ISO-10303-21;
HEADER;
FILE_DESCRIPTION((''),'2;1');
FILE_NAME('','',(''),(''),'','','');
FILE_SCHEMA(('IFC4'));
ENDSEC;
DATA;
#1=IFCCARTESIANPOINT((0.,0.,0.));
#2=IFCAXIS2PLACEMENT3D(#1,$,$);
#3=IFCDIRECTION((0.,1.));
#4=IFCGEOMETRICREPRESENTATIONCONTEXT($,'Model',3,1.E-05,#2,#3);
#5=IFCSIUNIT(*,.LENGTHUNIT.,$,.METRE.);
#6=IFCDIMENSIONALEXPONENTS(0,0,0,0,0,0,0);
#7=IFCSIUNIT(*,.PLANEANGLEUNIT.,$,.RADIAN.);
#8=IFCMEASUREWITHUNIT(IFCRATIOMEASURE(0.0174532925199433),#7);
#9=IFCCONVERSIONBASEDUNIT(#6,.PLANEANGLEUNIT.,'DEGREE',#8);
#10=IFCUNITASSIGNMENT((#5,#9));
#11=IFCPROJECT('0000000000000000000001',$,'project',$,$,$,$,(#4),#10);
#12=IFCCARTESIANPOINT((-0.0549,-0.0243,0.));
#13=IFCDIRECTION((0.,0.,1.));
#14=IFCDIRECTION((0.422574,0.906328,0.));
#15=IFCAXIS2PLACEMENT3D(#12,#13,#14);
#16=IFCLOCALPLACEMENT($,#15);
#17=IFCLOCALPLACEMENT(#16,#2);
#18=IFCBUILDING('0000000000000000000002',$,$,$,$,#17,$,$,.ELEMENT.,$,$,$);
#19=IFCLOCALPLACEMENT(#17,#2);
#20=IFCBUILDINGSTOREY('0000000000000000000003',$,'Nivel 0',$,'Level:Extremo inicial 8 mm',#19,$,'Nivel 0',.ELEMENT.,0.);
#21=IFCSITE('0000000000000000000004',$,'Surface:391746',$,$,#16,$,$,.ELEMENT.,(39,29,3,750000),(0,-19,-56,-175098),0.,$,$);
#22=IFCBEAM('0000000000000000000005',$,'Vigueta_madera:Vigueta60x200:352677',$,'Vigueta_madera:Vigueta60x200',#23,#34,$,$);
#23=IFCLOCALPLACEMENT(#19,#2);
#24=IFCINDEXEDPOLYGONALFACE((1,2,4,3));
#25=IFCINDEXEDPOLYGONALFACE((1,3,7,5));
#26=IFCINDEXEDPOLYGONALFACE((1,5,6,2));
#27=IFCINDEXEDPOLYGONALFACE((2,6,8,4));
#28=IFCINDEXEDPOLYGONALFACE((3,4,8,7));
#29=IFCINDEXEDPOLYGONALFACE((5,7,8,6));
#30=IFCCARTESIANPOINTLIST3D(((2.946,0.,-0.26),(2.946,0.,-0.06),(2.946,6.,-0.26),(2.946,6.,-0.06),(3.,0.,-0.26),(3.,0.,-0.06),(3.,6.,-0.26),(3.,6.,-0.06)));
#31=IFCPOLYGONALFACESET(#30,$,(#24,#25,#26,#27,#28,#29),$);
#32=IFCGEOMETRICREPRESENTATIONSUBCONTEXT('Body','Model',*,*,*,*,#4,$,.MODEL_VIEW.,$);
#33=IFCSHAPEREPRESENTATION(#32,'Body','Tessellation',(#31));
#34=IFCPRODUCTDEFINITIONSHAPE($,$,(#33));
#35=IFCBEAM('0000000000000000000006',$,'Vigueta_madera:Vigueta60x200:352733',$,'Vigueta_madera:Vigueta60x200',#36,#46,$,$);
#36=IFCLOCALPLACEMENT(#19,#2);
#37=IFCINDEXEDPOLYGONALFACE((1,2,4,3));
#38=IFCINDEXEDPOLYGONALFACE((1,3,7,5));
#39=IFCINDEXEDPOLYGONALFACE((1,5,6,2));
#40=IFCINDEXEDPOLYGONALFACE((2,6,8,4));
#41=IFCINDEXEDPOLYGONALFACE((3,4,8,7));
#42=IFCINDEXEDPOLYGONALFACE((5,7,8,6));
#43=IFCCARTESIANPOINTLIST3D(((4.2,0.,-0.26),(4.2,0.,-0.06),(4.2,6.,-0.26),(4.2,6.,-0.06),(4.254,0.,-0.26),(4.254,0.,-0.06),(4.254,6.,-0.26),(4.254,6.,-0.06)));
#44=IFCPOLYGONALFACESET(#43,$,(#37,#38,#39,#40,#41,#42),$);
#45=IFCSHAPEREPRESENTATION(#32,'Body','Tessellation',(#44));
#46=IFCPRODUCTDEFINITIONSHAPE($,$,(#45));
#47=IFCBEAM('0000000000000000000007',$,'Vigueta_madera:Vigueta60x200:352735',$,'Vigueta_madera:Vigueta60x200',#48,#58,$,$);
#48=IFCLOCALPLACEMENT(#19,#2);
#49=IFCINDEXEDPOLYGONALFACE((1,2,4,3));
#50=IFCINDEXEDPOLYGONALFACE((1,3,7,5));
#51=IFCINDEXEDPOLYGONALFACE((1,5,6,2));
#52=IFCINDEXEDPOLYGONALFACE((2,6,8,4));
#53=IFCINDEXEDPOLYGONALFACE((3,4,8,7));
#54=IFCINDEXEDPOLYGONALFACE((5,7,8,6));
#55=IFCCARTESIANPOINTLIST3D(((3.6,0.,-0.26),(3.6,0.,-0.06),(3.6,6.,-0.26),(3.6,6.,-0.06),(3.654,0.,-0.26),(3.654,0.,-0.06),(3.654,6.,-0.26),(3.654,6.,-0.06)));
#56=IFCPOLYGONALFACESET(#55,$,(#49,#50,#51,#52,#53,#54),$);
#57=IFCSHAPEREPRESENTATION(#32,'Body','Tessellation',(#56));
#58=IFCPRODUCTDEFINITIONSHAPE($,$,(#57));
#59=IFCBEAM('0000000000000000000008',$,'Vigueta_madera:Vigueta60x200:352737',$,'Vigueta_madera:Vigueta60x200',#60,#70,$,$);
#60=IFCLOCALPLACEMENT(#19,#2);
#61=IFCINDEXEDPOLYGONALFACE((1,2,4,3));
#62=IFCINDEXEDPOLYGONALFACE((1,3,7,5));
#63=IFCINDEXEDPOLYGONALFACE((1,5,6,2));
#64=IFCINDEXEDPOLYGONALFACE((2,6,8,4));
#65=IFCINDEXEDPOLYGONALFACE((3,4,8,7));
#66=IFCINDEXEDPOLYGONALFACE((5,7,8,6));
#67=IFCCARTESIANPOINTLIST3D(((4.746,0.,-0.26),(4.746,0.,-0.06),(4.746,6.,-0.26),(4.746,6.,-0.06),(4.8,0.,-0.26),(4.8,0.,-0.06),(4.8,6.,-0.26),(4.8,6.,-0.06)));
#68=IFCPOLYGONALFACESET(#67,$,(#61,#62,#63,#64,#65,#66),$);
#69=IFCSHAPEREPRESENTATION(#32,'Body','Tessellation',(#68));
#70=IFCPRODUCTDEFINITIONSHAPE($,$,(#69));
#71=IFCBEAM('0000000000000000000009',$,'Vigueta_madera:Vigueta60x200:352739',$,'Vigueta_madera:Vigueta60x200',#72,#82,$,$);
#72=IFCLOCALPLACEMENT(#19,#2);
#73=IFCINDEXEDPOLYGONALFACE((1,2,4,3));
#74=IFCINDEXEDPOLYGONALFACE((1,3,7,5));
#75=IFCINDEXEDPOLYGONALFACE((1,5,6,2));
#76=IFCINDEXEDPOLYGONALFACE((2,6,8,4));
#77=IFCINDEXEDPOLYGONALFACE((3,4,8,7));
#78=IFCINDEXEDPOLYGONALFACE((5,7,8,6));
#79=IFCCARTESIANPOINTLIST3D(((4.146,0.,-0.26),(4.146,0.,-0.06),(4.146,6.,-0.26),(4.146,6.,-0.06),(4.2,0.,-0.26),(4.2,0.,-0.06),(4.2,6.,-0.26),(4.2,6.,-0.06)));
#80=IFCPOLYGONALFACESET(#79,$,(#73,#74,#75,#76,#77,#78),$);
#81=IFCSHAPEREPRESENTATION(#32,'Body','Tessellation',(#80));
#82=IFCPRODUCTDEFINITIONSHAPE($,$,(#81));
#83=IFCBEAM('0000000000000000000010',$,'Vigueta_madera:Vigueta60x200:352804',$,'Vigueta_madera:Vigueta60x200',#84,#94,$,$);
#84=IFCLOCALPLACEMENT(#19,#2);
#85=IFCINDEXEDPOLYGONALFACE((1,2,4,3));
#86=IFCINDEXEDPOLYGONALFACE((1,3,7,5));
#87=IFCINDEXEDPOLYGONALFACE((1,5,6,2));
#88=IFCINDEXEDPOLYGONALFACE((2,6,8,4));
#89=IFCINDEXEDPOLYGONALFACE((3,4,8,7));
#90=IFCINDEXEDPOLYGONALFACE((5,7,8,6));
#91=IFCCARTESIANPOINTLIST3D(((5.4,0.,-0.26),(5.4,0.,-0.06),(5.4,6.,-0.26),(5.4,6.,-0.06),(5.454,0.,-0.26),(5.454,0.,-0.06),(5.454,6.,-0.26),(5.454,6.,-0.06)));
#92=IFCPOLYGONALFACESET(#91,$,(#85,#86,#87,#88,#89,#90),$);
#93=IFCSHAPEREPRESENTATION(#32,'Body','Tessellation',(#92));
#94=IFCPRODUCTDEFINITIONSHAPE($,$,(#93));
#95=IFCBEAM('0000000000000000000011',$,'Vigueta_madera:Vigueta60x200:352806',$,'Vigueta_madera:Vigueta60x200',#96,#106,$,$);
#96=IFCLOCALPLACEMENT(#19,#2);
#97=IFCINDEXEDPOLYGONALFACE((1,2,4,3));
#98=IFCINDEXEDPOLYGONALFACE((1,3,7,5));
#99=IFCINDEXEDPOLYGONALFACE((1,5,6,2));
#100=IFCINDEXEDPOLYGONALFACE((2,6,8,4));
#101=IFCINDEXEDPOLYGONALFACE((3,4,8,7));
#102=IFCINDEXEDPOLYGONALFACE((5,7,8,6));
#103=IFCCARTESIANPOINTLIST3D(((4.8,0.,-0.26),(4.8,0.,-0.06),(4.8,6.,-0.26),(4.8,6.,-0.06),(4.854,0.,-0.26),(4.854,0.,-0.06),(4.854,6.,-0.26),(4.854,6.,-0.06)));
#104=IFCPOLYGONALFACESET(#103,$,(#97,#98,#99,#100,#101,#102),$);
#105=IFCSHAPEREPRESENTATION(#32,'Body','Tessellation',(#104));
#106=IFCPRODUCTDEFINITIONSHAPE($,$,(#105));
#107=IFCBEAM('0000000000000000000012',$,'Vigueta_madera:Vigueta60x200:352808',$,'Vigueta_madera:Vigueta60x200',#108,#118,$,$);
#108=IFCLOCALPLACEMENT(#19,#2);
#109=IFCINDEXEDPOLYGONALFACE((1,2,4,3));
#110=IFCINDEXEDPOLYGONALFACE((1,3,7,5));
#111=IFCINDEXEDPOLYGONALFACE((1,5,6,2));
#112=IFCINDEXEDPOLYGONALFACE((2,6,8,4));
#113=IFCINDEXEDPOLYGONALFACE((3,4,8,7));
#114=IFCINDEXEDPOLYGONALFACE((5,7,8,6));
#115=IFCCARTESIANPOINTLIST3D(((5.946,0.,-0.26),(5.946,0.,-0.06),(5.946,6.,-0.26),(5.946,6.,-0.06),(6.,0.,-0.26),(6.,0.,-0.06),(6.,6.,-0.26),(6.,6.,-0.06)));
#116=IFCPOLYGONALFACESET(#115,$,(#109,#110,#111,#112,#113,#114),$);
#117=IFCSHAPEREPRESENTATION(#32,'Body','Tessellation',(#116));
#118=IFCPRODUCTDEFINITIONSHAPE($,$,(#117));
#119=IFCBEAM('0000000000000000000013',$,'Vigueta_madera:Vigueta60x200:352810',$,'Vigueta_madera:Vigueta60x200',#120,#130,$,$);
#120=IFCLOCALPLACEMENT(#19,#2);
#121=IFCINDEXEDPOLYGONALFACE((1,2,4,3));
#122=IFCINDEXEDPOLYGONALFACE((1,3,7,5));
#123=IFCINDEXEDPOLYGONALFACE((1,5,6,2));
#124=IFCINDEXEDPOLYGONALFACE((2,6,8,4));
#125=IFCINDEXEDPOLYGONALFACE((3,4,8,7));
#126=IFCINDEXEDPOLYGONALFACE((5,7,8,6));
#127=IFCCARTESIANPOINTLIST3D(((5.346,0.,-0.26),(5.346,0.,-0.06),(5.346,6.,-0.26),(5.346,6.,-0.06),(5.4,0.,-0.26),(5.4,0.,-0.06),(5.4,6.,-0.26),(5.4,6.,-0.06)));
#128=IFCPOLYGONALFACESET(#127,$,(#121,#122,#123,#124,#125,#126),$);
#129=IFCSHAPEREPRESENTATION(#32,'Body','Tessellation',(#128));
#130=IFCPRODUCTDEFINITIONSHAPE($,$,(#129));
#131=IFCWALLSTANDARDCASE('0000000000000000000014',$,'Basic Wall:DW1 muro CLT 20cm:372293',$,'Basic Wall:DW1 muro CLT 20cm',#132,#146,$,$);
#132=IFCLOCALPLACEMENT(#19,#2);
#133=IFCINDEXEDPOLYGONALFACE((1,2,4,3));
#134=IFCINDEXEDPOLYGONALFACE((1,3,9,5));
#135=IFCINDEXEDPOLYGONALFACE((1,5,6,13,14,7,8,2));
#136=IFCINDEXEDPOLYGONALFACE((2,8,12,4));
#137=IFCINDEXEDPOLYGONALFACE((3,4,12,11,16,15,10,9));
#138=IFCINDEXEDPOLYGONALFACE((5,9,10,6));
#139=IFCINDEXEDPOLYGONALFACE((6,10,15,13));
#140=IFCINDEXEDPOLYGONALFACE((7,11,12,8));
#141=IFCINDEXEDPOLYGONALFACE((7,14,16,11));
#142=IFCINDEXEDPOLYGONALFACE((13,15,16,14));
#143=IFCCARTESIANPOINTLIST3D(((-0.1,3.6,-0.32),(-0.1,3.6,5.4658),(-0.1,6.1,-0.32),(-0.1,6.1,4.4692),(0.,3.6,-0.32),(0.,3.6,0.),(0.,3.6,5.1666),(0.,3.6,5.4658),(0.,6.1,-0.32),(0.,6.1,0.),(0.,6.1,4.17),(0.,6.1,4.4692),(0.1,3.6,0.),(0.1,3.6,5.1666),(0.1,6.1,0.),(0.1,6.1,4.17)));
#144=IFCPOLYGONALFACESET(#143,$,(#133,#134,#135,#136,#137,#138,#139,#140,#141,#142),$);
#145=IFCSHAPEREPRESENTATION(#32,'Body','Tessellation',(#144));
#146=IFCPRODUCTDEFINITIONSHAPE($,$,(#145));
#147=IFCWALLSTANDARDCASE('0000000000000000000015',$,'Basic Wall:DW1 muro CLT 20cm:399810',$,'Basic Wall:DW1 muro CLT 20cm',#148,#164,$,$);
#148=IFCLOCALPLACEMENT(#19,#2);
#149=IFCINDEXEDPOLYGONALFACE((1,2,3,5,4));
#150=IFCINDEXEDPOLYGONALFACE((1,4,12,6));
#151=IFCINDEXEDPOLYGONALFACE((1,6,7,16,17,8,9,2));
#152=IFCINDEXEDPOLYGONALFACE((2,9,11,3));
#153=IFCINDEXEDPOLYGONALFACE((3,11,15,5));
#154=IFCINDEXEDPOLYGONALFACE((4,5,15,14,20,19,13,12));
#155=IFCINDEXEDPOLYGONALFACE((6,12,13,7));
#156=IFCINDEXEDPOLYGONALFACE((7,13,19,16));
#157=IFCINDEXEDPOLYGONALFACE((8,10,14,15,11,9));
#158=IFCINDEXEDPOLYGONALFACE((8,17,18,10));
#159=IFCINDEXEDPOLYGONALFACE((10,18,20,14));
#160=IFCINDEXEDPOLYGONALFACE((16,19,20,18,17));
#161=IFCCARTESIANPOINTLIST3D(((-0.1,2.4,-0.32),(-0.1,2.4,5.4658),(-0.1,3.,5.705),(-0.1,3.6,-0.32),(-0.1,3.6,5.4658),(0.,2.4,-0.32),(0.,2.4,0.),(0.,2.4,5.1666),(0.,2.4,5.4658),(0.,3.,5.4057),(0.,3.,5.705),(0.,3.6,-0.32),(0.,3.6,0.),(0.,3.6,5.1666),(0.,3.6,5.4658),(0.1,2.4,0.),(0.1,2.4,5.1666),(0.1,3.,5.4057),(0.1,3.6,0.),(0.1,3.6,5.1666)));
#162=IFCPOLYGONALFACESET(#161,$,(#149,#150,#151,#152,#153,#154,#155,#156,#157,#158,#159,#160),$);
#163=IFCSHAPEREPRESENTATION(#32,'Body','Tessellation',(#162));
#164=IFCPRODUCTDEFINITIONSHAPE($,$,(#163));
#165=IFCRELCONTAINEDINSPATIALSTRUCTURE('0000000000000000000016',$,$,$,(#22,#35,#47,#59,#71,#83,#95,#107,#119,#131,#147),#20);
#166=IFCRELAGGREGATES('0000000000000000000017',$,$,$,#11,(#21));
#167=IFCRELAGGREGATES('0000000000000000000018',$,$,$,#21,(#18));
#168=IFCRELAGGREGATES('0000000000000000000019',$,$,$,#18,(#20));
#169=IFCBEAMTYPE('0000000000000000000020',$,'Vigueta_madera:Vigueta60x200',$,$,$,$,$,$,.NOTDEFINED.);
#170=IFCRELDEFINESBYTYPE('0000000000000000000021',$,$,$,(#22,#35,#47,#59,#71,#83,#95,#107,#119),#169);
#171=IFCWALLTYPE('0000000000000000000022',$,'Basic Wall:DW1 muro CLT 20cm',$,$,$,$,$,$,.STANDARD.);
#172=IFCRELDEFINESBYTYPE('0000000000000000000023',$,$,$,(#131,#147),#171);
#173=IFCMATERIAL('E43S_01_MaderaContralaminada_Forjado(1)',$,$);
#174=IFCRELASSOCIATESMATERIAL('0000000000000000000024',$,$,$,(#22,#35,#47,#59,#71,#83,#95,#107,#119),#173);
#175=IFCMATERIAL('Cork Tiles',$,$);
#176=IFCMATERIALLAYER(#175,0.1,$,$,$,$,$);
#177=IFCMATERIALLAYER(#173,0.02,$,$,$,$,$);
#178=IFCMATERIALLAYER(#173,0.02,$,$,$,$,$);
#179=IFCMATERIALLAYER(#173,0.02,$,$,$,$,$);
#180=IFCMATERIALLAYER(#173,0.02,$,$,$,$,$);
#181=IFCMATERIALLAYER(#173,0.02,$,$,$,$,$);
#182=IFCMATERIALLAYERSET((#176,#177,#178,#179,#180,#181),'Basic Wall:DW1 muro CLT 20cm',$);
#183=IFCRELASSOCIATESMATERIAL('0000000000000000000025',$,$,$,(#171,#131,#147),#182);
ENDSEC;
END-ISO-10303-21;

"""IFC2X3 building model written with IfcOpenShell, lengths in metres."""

from ifc_helpers import new_model, entity, si_unit, converted_unit, direction, frame, frame_2d, origin, origin_2d_with_axis, place, context, subcontext, project, spatial, polyline, rectangle, extrude, clip, bounded_halfspace, material, layer, layer_set, layer_usage, type_object, element, save


model = new_model("IFC2X3")

# Units and contexts
model_context = context("Model", 3, precision=1e-05, world=origin(), true_north=direction((0.0, 1.0)))
body_context = subcontext(model_context, "Body", "Model", "MODEL_VIEW")
ifc_project = project(units=[si_unit("LENGTHUNIT", "METRE"), converted_unit("PLANEANGLEUNIT", "DEGREE", entity("IfcRatioMeasure", 0.0174532925199433), si_unit("PLANEANGLEUNIT", "RADIAN"), dimensions=[0, 0, 0, 0, 0, 0, 0])], contexts=[model_context])

# Site, building, storey
site_placement = place(None, frame((-0.0549, -0.0243, 0.0), z_axis=(0.0, 0.0, 1.0), x_axis=(0.422574, 0.906328, 0.0)))
site = spatial("IfcSite", under=ifc_project, at=site_placement, Name="Surface:391746", CompositionType="ELEMENT", RefLatitude=(39, 29, 3, 750000), RefLongitude=(0, -19, -56, -175098), RefElevation=0.0)
building_placement = place(site_placement, origin())
building = spatial("IfcBuilding", under=site, at=building_placement, CompositionType="ELEMENT")
storey_placement = place(building_placement, origin())
storey = spatial("IfcBuildingStorey", under=building, at=storey_placement, Name="Nivel 0", ObjectType="Level:Extremo inicial 8 mm", LongName="Nivel 0", CompositionType="ELEMENT", Elevation=0.0)

# Beams
ifc_material_1 = material(Name="E43S_01_MaderaContralaminada_Forjado(1)")
beam_type = type_object("IfcBeamType", Name="Vigueta_madera:Vigueta60x200", PredefinedType="NOTDEFINED")
beam_1_placement = place(storey_placement, frame((2.973, 0.0, -0.06), z_axis=(0.0, 0.0, 1.0), x_axis=(0.0, 1.0, 0.0)))
element("IfcBeam", 1, at=beam_1_placement, inside=storey, type_object=beam_type, material=ifc_material_1, Name="Vigueta_madera:Vigueta60x200:352677", ObjectType="Vigueta_madera:Vigueta60x200", context=body_context, shape_type="SweptSolid", body=[
    extrude(rectangle(XDim=0.2, YDim=0.054, at=frame_2d((0.0, 0.0), x_axis=(1.0, 0.0))), frame((0.0, 0.0, -0.1), z_axis=(1.0, 0.0, 0.0), x_axis=(0.0, 0.0, -1.0)), (0.0, 0.0, 1.0), 6.0),
])
beam_2_placement = place(storey_placement, frame((4.227, 0.0, -0.06), z_axis=(0.0, 0.0, 1.0), x_axis=(0.0, 1.0, 0.0)))
element("IfcBeam", 2, at=beam_2_placement, inside=storey, type_object=beam_type, material=ifc_material_1, Name="Vigueta_madera:Vigueta60x200:352733", ObjectType="Vigueta_madera:Vigueta60x200", context=body_context, shape_type="SweptSolid", body=[
    extrude(rectangle(XDim=0.2, YDim=0.054, at=frame_2d((0.0, 0.0), x_axis=(1.0, 0.0))), frame((0.0, 0.0, -0.1), z_axis=(1.0, 0.0, 0.0), x_axis=(0.0, 0.0, -1.0)), (0.0, 0.0, 1.0), 6.0),
])
beam_3_placement = place(storey_placement, frame((3.627, 0.0, -0.06), z_axis=(0.0, 0.0, 1.0), x_axis=(0.0, 1.0, 0.0)))
element("IfcBeam", 3, at=beam_3_placement, inside=storey, type_object=beam_type, material=ifc_material_1, Name="Vigueta_madera:Vigueta60x200:352735", ObjectType="Vigueta_madera:Vigueta60x200", context=body_context, shape_type="SweptSolid", body=[
    extrude(rectangle(XDim=0.2, YDim=0.054, at=frame_2d((0.0, 0.0), x_axis=(1.0, 0.0))), frame((0.0, 0.0, -0.1), z_axis=(1.0, 0.0, 0.0), x_axis=(0.0, 0.0, -1.0)), (0.0, 0.0, 1.0), 6.0),
])
beam_4_placement = place(storey_placement, frame((4.773, 0.0, -0.06), z_axis=(0.0, 0.0, 1.0), x_axis=(0.0, 1.0, 0.0)))
element("IfcBeam", 4, at=beam_4_placement, inside=storey, type_object=beam_type, material=ifc_material_1, Name="Vigueta_madera:Vigueta60x200:352737", ObjectType="Vigueta_madera:Vigueta60x200", context=body_context, shape_type="SweptSolid", body=[
    extrude(rectangle(XDim=0.2, YDim=0.054, at=origin_2d_with_axis()), frame((0.0, 0.0, -0.1), z_axis=(1.0, 0.0, 0.0), x_axis=(0.0, 0.0, -1.0)), (0.0, 0.0, 1.0), 6.0),
])
beam_5_placement = place(storey_placement, frame((4.173, 0.0, -0.06), z_axis=(0.0, 0.0, 1.0), x_axis=(0.0, 1.0, 0.0)))
element("IfcBeam", 5, at=beam_5_placement, inside=storey, type_object=beam_type, material=ifc_material_1, Name="Vigueta_madera:Vigueta60x200:352739", ObjectType="Vigueta_madera:Vigueta60x200", context=body_context, shape_type="SweptSolid", body=[
    extrude(rectangle(XDim=0.2, YDim=0.054, at=frame_2d((0.0, 0.0), x_axis=(1.0, 0.0))), frame((0.0, 0.0, -0.1), z_axis=(1.0, 0.0, 0.0), x_axis=(0.0, 0.0, -1.0)), (0.0, 0.0, 1.0), 6.0),
])
beam_6_placement = place(storey_placement, frame((5.427, 0.0, -0.06), z_axis=(0.0, 0.0, 1.0), x_axis=(0.0, 1.0, 0.0)))
element("IfcBeam", 6, at=beam_6_placement, inside=storey, type_object=beam_type, material=ifc_material_1, Name="Vigueta_madera:Vigueta60x200:352804", ObjectType="Vigueta_madera:Vigueta60x200", context=body_context, shape_type="SweptSolid", body=[
    extrude(rectangle(XDim=0.2, YDim=0.054, at=frame_2d((0.0, 0.0), x_axis=(1.0, 0.0))), frame((0.0, 0.0, -0.1), z_axis=(1.0, 0.0, 0.0), x_axis=(0.0, 0.0, -1.0)), (0.0, 0.0, 1.0), 6.0),
])
beam_7_placement = place(storey_placement, frame((4.827, 0.0, -0.06), z_axis=(0.0, 0.0, 1.0), x_axis=(0.0, 1.0, 0.0)))
element("IfcBeam", 7, at=beam_7_placement, inside=storey, type_object=beam_type, material=ifc_material_1, Name="Vigueta_madera:Vigueta60x200:352806", ObjectType="Vigueta_madera:Vigueta60x200", context=body_context, shape_type="SweptSolid", body=[
    extrude(rectangle(XDim=0.2, YDim=0.054, at=frame_2d((0.0, 0.0), x_axis=(1.0, 0.0))), frame((0.0, 0.0, -0.1), z_axis=(1.0, 0.0, 0.0), x_axis=(0.0, 0.0, -1.0)), (0.0, 0.0, 1.0), 6.0),
])
beam_8_placement = place(storey_placement, frame((5.973, 0.0, -0.06), z_axis=(0.0, 0.0, 1.0), x_axis=(0.0, 1.0, 0.0)))
element("IfcBeam", 8, at=beam_8_placement, inside=storey, type_object=beam_type, material=ifc_material_1, Name="Vigueta_madera:Vigueta60x200:352808", ObjectType="Vigueta_madera:Vigueta60x200", context=body_context, shape_type="SweptSolid", body=[
    extrude(rectangle(XDim=0.2, YDim=0.054, at=origin_2d_with_axis()), frame((0.0, 0.0, -0.1), z_axis=(1.0, 0.0, 0.0), x_axis=(0.0, 0.0, -1.0)), (0.0, 0.0, 1.0), 6.0),
])
beam_9_placement = place(storey_placement, frame((5.373, 0.0, -0.06), z_axis=(0.0, 0.0, 1.0), x_axis=(0.0, 1.0, 0.0)))
element("IfcBeam", 9, at=beam_9_placement, inside=storey, type_object=beam_type, material=ifc_material_1, Name="Vigueta_madera:Vigueta60x200:352810", ObjectType="Vigueta_madera:Vigueta60x200", context=body_context, shape_type="SweptSolid", body=[
    extrude(rectangle(XDim=0.2, YDim=0.054, at=origin_2d_with_axis()), frame((0.0, 0.0, -0.1), z_axis=(1.0, 0.0, 0.0), x_axis=(0.0, 0.0, -1.0)), (0.0, 0.0, 1.0), 6.0),
])

# Walls
ifc_material_2 = material(Name="Cork Tiles")
ifc_layer_1 = layer(ifc_material_2, 0.1)
ifc_layer_2 = layer(ifc_material_1, 0.02)
ifc_layer_3 = layer(ifc_material_1, 0.02)
ifc_layer_4 = layer(ifc_material_1, 0.02)
ifc_layer_5 = layer(ifc_material_1, 0.02)
ifc_layer_6 = layer(ifc_material_1, 0.02)
ifc_layer_set_1 = layer_set([ifc_layer_1, ifc_layer_2, ifc_layer_3, ifc_layer_4, ifc_layer_5, ifc_layer_6], Name="Basic Wall:DW1 muro CLT 20cm")
ifc_layer_usage_1 = layer_usage(ifc_layer_set_1, "AXIS2", "NEGATIVE", 0.1)
wall_type_1 = type_object("IfcWallType", Name="Basic Wall:DW1 muro CLT 20cm", PredefinedType="STANDARD", material=ifc_layer_set_1)
wall_1_placement = place(storey_placement, frame((0.0, 3.6, -0.32), z_axis=(0.0, 0.0, 1.0), x_axis=(0.0, 1.0, 0.0)))
element("IfcWallStandardCase", 10, at=wall_1_placement, inside=storey, type_object=wall_type_1, material=ifc_layer_usage_1, Name="Basic Wall:DW1 muro CLT 20cm:372293", ObjectType="Basic Wall:DW1 muro CLT 20cm", context=body_context, shape_type="Clipping", body=[
    clip(clip(clip(extrude(rectangle(XDim=2.5, YDim=0.2, at=frame_2d((1.25, 0.0), x_axis=(-1.0, 0.0))), origin(), (0.0, 0.0, 1.0), 5.7858), bounded_halfspace(frame((0.0, -0.1, 5.4866), z_axis=(0.370288, 0.0, 0.928917), x_axis=(0.0, 1.0, 0.0)), False, frame((0.0, -0.1, 5.4866)), polyline([(0.0, 0.0), (2.3, 0.0), (2.5, 0.0), (2.5, 0.1), (0.0, 0.1), (0.0, 0.0)]))), bounded_halfspace(frame((2.5, 0.0, 4.7892), z_axis=(0.370288, 0.0, 0.928917), x_axis=(0.0, 1.0, 0.0)), False, frame((2.5, 0.0, 4.7892)), polyline([(0.0, 0.0), (0.0, 0.1), (-2.5, 0.1), (-2.5, 0.0), (0.0, 0.0)]))), bounded_halfspace(frame((2.5, -0.1, 0.32), z_axis=(0.0, 0.0, -1.0), x_axis=(0.0, 1.0, 0.0)), False, frame((2.5, -0.1, 0.32)), polyline([(0.0, 0.0), (0.0, 0.1), (-2.5, 0.1), (-2.5, 0.0), (-0.2, 0.0), (-0.1, 0.0), (0.0, 0.0)]))),
])
ifc_layer_usage_2 = layer_usage(ifc_layer_set_1, "AXIS2", "NEGATIVE", 0.1)
wall_2_placement = place(storey_placement, frame((0.0, 2.4, -0.32), z_axis=(0.0, 0.0, 1.0), x_axis=(0.0, 1.0, 0.0)))
element("IfcWallStandardCase", 11, at=wall_2_placement, inside=storey, type_object=wall_type_1, material=ifc_layer_usage_2, Name="Basic Wall:DW1 muro CLT 20cm:399810", ObjectType="Basic Wall:DW1 muro CLT 20cm", context=body_context, shape_type="Clipping", body=[
    clip(clip(clip(clip(clip(extrude(rectangle(XDim=1.2, YDim=0.2, at=frame_2d((0.6, 0.0), x_axis=(-1.0, 0.0))), origin(), (0.0, 0.0, 1.0), 6.025), bounded_halfspace(frame((0.0, -0.1, 5.4866), z_axis=(-0.370288, 0.0, 0.928917), x_axis=(0.0, -1.0, 0.0)), False, frame((0.0, -0.1, 5.4866)), polyline([(0.0, 0.0), (0.6, 0.0), (0.6, 0.1), (0.0, 0.1), (0.0, 0.0)]))), bounded_halfspace(frame((0.6, -0.1, 5.7257), z_axis=(0.370288, 0.0, 0.928917), x_axis=(0.0, 1.0, 0.0)), False, frame((0.6, -0.1, 5.7257)), polyline([(0.0, 0.0), (0.6, 0.0), (0.6, 0.1), (0.0, 0.1), (0.0, 0.0)]))), bounded_halfspace(frame((1.2, 0.0, 5.7858), z_axis=(0.370288, 0.0, 0.928917), x_axis=(0.0, 1.0, 0.0)), False, frame((1.2, 0.0, 5.7858)), polyline([(0.0, 0.0), (0.0, 0.1), (-0.6, 0.1), (-0.6, 0.0), (0.0, 0.0)]))), bounded_halfspace(frame((0.6, 0.1, 6.025), z_axis=(-0.370288, 0.0, 0.928917), x_axis=(0.0, -1.0, 0.0)), False, frame((0.6, 0.1, 6.025)), polyline([(0.0, 0.0), (-0.6, 0.0), (-0.6, -0.1), (0.0, -0.1), (0.0, 0.0)]))), bounded_halfspace(frame((1.2, -0.1, 0.32), z_axis=(0.0, 0.0, -1.0), x_axis=(0.0, 1.0, 0.0)), False, frame((1.2, -0.1, 0.32)), polyline([(0.0, 0.0), (0.0, 0.1), (-1.2, 0.1), (-1.2, 0.0), (0.0, 0.0)]))),
])

save(model, "model.ifc")
